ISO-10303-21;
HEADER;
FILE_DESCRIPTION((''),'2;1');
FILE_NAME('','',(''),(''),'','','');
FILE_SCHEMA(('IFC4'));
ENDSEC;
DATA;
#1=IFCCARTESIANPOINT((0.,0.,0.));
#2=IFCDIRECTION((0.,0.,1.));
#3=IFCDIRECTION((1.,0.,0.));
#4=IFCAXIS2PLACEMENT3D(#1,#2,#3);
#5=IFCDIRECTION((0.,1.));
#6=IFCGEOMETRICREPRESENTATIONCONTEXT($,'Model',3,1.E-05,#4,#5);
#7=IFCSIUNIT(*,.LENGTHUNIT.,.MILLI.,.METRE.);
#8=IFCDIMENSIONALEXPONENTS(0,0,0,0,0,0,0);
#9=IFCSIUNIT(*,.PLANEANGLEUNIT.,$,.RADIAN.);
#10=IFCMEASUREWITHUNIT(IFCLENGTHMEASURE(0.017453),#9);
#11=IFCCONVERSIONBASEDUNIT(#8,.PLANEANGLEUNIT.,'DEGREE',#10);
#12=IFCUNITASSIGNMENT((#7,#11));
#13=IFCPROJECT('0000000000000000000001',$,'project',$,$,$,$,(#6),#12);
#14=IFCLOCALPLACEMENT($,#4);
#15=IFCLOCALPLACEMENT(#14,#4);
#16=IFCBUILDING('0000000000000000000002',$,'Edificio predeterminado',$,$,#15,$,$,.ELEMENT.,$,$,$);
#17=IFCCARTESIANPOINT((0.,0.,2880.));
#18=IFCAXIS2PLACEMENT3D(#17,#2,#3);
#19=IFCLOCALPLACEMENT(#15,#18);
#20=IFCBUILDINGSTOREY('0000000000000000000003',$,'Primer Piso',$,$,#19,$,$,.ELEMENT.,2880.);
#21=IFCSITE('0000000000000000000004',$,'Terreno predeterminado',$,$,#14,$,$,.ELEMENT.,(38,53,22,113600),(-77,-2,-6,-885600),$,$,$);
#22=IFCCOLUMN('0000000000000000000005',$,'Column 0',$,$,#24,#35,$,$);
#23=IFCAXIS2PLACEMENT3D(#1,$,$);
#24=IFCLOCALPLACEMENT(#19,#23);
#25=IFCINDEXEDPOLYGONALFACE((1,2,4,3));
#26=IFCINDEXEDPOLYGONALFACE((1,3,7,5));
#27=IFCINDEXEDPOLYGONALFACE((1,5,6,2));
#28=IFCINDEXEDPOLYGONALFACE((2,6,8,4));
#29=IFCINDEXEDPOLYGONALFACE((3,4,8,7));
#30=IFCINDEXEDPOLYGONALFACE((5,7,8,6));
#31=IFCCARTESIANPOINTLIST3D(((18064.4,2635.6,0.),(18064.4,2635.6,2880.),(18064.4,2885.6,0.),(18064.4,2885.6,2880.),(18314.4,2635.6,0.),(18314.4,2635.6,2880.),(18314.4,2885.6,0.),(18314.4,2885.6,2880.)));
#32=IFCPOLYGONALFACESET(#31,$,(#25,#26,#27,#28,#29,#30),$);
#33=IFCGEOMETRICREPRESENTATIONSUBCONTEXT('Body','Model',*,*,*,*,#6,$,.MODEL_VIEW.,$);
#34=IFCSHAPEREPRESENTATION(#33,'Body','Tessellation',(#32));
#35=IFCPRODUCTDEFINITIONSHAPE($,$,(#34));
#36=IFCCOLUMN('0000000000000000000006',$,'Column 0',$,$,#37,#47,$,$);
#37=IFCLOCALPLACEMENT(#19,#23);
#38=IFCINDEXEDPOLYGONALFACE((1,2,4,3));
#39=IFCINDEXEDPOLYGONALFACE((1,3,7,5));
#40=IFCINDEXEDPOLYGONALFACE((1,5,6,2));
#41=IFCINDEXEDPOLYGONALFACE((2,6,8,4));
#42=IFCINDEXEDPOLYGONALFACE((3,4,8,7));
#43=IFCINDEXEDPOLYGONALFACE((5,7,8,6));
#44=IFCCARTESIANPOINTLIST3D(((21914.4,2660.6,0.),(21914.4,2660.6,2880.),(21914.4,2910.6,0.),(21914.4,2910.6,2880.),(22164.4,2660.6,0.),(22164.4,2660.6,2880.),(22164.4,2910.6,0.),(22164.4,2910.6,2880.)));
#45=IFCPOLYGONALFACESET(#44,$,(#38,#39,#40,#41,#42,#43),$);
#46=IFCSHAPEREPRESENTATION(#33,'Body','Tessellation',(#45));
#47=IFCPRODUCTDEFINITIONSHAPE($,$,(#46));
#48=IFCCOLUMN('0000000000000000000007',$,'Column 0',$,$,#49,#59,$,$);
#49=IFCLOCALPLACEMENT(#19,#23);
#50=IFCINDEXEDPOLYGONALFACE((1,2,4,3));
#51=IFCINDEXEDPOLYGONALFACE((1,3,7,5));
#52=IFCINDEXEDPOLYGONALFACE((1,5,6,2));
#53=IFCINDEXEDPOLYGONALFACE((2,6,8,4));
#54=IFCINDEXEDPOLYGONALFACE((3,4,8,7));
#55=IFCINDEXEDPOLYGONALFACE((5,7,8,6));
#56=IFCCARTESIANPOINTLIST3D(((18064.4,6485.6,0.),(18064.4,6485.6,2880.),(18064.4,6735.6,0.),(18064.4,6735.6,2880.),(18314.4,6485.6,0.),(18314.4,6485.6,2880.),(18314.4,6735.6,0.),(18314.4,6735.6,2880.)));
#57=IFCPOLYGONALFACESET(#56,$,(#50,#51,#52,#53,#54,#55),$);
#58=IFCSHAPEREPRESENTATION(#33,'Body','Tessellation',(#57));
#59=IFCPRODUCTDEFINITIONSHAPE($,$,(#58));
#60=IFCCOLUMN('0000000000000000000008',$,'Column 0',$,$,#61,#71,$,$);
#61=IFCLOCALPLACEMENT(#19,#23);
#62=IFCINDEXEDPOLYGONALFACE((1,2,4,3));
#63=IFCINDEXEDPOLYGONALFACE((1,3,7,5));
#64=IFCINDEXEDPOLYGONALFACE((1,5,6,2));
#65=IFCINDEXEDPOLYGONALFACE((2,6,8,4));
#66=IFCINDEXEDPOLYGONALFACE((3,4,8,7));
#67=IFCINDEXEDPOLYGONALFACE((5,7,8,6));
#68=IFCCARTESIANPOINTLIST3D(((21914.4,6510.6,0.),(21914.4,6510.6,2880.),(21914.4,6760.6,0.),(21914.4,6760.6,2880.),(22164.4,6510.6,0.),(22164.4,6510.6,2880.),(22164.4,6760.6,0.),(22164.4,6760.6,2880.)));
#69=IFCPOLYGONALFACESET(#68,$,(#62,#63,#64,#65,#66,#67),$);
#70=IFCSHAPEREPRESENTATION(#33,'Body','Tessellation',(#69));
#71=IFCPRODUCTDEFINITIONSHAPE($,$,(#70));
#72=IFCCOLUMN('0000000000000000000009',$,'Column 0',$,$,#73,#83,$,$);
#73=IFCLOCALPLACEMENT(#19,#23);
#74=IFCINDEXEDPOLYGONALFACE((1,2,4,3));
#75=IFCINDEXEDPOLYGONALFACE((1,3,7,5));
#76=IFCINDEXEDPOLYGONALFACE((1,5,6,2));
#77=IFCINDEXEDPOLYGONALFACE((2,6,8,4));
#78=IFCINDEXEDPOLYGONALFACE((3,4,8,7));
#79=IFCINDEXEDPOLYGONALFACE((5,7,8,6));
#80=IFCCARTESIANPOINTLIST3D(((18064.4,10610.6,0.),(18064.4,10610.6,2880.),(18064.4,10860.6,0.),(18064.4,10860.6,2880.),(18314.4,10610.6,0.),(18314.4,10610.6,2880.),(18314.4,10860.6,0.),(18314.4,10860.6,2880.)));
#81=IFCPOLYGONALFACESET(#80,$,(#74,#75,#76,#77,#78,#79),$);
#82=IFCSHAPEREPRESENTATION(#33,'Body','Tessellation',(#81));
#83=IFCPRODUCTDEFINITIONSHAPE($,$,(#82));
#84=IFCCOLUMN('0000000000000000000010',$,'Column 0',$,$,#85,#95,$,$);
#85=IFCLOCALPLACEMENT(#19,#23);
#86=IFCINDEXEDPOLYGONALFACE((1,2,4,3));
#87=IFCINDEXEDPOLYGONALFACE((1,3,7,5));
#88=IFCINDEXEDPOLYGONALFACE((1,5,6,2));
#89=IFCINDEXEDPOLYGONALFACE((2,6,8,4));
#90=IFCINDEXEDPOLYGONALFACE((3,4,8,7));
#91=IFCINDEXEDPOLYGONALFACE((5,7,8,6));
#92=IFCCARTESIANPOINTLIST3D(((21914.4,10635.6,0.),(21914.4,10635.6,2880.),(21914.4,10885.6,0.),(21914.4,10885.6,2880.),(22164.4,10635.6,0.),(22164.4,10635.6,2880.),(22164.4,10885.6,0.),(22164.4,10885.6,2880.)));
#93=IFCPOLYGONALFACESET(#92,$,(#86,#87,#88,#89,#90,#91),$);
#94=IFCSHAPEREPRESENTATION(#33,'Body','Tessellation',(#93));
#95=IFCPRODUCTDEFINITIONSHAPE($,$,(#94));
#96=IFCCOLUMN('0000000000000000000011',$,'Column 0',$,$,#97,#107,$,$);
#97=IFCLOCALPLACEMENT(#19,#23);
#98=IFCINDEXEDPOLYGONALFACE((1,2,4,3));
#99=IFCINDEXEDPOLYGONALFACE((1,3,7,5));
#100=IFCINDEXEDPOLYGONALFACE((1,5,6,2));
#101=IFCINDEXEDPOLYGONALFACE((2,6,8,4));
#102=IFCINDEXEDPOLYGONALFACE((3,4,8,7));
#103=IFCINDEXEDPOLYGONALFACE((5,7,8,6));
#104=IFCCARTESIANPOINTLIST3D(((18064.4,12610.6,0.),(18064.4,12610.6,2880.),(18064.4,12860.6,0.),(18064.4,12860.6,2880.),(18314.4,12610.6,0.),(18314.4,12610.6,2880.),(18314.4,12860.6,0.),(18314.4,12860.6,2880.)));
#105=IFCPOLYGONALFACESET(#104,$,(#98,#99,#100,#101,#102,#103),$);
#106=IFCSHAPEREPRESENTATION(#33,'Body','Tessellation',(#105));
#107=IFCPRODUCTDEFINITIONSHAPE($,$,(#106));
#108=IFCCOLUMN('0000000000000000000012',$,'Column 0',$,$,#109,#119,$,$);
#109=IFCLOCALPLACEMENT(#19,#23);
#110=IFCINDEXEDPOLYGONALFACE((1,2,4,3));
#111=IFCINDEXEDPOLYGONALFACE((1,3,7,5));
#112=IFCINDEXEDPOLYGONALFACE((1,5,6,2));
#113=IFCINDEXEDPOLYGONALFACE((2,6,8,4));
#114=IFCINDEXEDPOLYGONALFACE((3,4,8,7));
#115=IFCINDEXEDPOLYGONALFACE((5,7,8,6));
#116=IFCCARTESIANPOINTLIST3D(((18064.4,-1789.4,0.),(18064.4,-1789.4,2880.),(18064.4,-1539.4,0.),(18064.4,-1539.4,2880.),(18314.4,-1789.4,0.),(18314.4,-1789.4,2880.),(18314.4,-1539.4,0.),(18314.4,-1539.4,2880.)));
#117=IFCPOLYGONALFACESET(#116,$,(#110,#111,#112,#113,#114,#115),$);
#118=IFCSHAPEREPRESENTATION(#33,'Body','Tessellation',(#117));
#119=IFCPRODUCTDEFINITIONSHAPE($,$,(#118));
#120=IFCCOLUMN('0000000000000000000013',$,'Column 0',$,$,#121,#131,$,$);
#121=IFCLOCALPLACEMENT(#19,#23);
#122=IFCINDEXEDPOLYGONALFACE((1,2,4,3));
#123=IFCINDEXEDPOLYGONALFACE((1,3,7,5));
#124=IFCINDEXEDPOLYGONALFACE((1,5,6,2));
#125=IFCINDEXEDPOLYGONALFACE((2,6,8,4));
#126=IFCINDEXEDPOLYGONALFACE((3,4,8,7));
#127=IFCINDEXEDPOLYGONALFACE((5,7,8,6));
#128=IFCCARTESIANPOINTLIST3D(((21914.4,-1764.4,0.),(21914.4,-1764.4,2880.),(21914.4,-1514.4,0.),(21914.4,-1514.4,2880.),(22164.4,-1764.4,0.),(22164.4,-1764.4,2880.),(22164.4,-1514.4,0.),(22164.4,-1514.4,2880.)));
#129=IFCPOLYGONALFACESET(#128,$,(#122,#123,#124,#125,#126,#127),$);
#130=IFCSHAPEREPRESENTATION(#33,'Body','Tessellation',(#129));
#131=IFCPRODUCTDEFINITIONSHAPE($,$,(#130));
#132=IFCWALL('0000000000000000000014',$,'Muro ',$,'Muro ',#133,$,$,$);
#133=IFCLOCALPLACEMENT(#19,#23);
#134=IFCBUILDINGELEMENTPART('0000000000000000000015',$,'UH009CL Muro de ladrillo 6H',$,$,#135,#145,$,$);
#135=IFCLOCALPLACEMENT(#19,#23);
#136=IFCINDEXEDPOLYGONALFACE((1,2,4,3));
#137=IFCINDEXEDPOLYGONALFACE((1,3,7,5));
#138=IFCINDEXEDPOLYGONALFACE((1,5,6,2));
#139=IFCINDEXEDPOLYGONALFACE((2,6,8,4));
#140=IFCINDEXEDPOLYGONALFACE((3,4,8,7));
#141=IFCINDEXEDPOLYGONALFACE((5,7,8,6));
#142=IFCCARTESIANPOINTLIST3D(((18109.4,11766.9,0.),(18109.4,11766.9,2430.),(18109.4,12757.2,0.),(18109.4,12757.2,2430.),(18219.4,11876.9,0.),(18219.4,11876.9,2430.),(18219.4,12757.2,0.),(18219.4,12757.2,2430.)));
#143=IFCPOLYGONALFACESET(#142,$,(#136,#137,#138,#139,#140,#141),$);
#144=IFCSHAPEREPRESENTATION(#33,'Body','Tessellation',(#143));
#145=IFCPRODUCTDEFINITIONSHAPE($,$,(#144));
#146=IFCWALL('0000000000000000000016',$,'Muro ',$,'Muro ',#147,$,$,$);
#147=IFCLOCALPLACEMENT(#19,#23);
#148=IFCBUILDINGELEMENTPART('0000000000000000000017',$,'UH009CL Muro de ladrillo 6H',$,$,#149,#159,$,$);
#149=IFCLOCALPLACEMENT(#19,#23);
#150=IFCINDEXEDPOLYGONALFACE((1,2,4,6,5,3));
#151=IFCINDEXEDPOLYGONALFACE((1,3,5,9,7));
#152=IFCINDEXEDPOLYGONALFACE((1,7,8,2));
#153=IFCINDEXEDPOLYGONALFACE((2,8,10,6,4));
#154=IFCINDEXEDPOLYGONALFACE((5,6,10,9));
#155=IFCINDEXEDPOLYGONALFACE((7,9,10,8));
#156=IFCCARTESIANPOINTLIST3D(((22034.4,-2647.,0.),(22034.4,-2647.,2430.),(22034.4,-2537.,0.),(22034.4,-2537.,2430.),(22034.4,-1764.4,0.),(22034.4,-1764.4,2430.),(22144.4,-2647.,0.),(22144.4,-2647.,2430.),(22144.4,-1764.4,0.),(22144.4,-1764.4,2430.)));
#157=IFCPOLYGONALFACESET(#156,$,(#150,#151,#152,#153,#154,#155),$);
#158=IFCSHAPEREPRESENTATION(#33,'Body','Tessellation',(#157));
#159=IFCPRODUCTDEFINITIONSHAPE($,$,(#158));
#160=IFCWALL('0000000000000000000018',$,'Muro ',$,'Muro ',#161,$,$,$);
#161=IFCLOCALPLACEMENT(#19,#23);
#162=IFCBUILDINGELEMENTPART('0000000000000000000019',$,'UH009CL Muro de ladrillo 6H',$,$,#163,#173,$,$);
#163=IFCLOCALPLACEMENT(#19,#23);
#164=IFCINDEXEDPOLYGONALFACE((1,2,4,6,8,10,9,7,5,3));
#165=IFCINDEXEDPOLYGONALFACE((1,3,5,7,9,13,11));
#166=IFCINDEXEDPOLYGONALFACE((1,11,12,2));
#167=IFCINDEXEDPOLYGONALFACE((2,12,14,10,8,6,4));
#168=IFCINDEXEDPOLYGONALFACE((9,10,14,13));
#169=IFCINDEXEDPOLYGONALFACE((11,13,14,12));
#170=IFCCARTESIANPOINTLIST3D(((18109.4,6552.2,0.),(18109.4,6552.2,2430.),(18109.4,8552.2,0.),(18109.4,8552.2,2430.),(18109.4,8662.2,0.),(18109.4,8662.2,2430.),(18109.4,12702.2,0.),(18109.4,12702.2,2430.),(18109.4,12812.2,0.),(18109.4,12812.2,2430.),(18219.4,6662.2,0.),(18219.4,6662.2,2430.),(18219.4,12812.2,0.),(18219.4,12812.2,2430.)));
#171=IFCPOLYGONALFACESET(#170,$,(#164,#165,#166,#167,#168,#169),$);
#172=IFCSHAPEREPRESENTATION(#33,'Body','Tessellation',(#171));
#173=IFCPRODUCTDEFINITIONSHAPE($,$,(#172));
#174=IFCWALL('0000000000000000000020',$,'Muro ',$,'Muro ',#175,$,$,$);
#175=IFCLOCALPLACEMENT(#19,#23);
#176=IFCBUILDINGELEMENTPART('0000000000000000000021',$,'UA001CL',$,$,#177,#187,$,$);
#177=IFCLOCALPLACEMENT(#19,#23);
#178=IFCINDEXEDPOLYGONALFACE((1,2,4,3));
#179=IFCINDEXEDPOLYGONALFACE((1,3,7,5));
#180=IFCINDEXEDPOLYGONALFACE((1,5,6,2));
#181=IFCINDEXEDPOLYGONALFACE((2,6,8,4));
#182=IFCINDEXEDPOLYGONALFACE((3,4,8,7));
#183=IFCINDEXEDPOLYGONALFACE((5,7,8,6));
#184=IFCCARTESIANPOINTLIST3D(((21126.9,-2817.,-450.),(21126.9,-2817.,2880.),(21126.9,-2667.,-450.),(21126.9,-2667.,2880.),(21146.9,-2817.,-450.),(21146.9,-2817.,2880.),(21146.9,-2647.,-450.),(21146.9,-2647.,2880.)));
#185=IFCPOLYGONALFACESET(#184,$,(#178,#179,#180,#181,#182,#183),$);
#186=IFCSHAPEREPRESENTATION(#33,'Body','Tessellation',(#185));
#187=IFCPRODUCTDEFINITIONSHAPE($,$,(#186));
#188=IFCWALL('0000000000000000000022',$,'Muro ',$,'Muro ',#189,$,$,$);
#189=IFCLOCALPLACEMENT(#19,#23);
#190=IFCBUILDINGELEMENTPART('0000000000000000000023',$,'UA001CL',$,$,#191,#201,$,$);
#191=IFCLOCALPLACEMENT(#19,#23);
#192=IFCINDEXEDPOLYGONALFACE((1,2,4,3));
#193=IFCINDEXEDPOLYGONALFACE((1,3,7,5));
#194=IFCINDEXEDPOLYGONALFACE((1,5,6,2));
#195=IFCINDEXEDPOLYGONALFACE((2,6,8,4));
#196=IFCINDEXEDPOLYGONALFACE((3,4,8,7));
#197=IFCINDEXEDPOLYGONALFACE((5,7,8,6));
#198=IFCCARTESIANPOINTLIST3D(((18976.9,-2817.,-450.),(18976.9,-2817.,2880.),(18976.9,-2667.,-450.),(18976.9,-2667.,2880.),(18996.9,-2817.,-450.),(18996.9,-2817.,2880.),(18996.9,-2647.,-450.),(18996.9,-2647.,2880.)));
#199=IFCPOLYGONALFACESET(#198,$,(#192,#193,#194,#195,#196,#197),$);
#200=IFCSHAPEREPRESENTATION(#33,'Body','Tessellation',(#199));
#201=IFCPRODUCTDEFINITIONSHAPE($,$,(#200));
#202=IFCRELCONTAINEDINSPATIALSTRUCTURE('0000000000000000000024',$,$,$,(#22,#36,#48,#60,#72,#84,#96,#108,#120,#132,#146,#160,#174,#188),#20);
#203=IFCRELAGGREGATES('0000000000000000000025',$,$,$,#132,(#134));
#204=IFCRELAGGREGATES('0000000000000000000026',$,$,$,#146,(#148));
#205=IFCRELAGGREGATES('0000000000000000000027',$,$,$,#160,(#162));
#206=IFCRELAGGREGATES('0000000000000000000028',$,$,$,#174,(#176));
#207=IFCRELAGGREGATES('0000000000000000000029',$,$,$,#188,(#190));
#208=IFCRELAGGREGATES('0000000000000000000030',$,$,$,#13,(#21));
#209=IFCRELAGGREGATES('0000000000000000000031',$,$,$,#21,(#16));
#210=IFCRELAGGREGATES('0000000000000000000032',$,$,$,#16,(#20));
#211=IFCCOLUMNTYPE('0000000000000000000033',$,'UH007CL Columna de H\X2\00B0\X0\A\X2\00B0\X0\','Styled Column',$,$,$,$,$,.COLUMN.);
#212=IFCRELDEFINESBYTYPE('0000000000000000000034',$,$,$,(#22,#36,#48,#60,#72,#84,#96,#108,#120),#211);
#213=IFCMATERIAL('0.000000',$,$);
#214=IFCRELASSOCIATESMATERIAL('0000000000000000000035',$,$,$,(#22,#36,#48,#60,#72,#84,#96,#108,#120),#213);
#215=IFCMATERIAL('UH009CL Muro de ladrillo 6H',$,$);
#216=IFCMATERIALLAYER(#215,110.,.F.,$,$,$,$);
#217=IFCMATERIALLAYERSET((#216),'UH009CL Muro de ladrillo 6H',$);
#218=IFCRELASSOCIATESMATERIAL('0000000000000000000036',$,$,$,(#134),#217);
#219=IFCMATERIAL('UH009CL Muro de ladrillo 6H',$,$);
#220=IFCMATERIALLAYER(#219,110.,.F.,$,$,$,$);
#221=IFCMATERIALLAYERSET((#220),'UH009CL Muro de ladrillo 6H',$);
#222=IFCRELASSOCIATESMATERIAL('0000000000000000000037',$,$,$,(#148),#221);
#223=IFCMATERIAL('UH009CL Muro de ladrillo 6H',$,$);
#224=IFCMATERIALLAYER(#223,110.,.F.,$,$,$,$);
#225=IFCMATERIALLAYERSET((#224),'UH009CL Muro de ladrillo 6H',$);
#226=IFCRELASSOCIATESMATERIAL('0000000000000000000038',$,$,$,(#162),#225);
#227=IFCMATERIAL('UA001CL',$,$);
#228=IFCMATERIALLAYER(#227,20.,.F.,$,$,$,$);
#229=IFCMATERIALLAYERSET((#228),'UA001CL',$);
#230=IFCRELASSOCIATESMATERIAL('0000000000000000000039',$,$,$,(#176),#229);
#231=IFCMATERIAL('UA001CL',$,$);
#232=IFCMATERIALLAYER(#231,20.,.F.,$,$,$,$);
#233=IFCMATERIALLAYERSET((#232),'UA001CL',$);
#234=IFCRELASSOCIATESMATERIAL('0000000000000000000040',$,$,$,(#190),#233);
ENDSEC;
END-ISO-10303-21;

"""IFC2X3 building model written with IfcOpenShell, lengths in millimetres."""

from ifc_helpers import new_model, entity, si_unit, converted_unit, direction, frame, origin_with_axes, place, context, subcontext, project, spatial, polyline, outline, extrude, clip, bounded_halfspace, material, layer, layer_set, layer_usage, type_object, element, aggregate, save


model = new_model("IFC2X3")

# Units and contexts
model_context = context("Model", 3, precision=1e-05, world=origin_with_axes(), true_north=direction((0.0, 1.0)))
body_context = subcontext(model_context, "Body", "Model", "MODEL_VIEW")
ifc_project = project(units=[si_unit("LENGTHUNIT", "METRE", prefix="MILLI"), converted_unit("PLANEANGLEUNIT", "DEGREE", entity("IfcLengthMeasure", 0.017453), si_unit("PLANEANGLEUNIT", "RADIAN"), dimensions=[0, 0, 0, 0, 0, 0, 0])], contexts=[model_context])

# Site, building, storey
site_placement = place(None, origin_with_axes())
site = spatial("IfcSite", under=ifc_project, at=site_placement, Name="Terreno predeterminado", CompositionType="ELEMENT", RefLatitude=(38, 53, 22, 113600), RefLongitude=(-77, -2, -6, -885600))
building_placement = place(site_placement, origin_with_axes())
building = spatial("IfcBuilding", under=site, at=building_placement, Name="Edificio predeterminado", CompositionType="ELEMENT")
storey_placement = place(building_placement, frame((0.0, 0.0, 2880.0), z_axis=(0.0, 0.0, 1.0), x_axis=(1.0, 0.0, 0.0)))
storey = spatial("IfcBuildingStorey", under=building, at=storey_placement, Name="Primer Piso", CompositionType="ELEMENT", Elevation=2880.0)

# Columns
ifc_material_1 = material(Name="0.000000")
column_type = type_object("IfcColumnType", Name="UH007CL Columna de H°A°", Description="Styled Column", PredefinedType="COLUMN")
for number, where, z_axis, x_axis, name in (
    (1, (18189.4, 2760.6, 0.0), (0.0, 0.0, 1.0), (1.0, 0.0, 0.0), "Column 0"),
    (2, (22039.4, 2785.6, 0.0), (0.0, 0.0, 1.0), (1.0, 0.0, 0.0), "Column 0"),
    (3, (18189.4, 6610.6, 0.0), (0.0, 0.0, 1.0), (1.0, 0.0, 0.0), "Column 0"),
    (4, (22039.4, 6635.6, 0.0), (0.0, 0.0, 1.0), (1.0, 0.0, 0.0), "Column 0"),
    (5, (18189.4, 10735.6, 0.0), (0.0, 0.0, 1.0), (1.0, 0.0, 0.0), "Column 0"),
    (6, (22039.4, 10760.6, 0.0), (0.0, 0.0, 1.0), (1.0, 0.0, 0.0), "Column 0"),
    (7, (18189.4, 12735.6, 0.0), (0.0, 0.0, 1.0), (1.0, 0.0, 0.0), "Column 0"),
    (8, (18189.4, -1664.4, 0.0), (0.0, 0.0, 1.0), (1.0, 0.0, 0.0), "Column 0"),
    (9, (22039.4, -1639.4, 0.0), (0.0, 0.0, 1.0), (1.0, 0.0, 0.0), "Column 0"),
):
    element("IfcColumn", number, at=place(storey_placement, frame(where, z_axis=z_axis, x_axis=x_axis)), inside=storey, type_object=column_type, material=ifc_material_1, Name=name, context=body_context, shape_type="SweptSolid", body=[
        extrude(outline(polyline([(-125.0, -125.0), (125.0, -125.0), (125.0, 125.0), (-125.0, 125.0), (-125.0, -125.0)])), origin_with_axes(), (0.0, 0.0, 1.0), 2880.0),
    ])

# Walls, building element parts
wall_1_placement = place(storey_placement, frame((18164.4, 11821.9, 0.0), z_axis=(0.0, 0.0, 1.0), x_axis=(0.0, 1.0, 0.0)))
wall_1 = element("IfcWall", 10, at=wall_1_placement, inside=storey, Name="Muro ", ObjectType="Muro ")
ifc_material_2 = material(Name="UH009CL Muro de ladrillo 6H")
ifc_layer_1 = layer(ifc_material_2, 110.0, ventilated=False)
ifc_layer_set_1 = layer_set([ifc_layer_1], Name="UH009CL Muro de ladrillo 6H")
ifc_layer_usage_1 = layer_usage(ifc_layer_set_1, "AXIS2", "NEGATIVE", -55.0)
building_element_part_1_placement = place(wall_1_placement, origin_with_axes())
building_element_part_1 = element("IfcBuildingElementPart", 11, at=building_element_part_1_placement, material=ifc_layer_usage_1, Name="UH009CL Muro de ladrillo 6H", context=body_context, shape_type="SweptSolid", body=[
    extrude(outline(polyline([(935.2, 55.0), (935.2, -55.0), (55.0, -55.0), (-55.0, 55.0), (935.2, 55.0)])), origin_with_axes(), (0.0, 0.0, 1.0), 2430.0),
])
aggregate(wall_1, [building_element_part_1])
wall_2_placement = place(storey_placement, frame((22089.4, -1764.4, 0.0), z_axis=(0.0, 0.0, 1.0), x_axis=(0.0, -1.0, 0.0)))
wall_2 = element("IfcWall", 12, at=wall_2_placement, inside=storey, Name="Muro ", ObjectType="Muro ")
ifc_material_3 = material(Name="UH009CL Muro de ladrillo 6H")
ifc_layer_2 = layer(ifc_material_3, 110.0, ventilated=False)
ifc_layer_set_2 = layer_set([ifc_layer_2], Name="UH009CL Muro de ladrillo 6H")
ifc_layer_usage_2 = layer_usage(ifc_layer_set_2, "AXIS2", "NEGATIVE", -55.0)
building_element_part_2_placement = place(wall_2_placement, origin_with_axes())
building_element_part_2 = element("IfcBuildingElementPart", 13, at=building_element_part_2_placement, material=ifc_layer_usage_2, Name="UH009CL Muro de ladrillo 6H", context=body_context, shape_type="SweptSolid", body=[
    extrude(outline(polyline([(882.6, 55.0), (882.6, -55.0), (772.6, -55.0), (0.0, -55.0), (0.0, 55.0), (882.6, 55.0)])), origin_with_axes(), (0.0, 0.0, 1.0), 2430.0),
])
aggregate(wall_2, [building_element_part_2])
wall_3_placement = place(storey_placement, frame((18164.4, 12757.2, 0.0), z_axis=(0.0, 0.0, 1.0), x_axis=(0.0, -1.0, 0.0)))
wall_3 = element("IfcWall", 14, at=wall_3_placement, inside=storey, Name="Muro ", ObjectType="Muro ")
ifc_material_4 = material(Name="UH009CL Muro de ladrillo 6H")
ifc_layer_3 = layer(ifc_material_4, 110.0, ventilated=False)
ifc_layer_set_3 = layer_set([ifc_layer_3], Name="UH009CL Muro de ladrillo 6H")
ifc_layer_usage_3 = layer_usage(ifc_layer_set_3, "AXIS2", "NEGATIVE", -55.0)
building_element_part_3_placement = place(wall_3_placement, origin_with_axes())
building_element_part_3 = element("IfcBuildingElementPart", 15, at=building_element_part_3_placement, material=ifc_layer_usage_3, Name="UH009CL Muro de ladrillo 6H", context=body_context, shape_type="SweptSolid", body=[
    extrude(outline(polyline([(6095.0, 55.0), (6205.0, -55.0), (4205.0, -55.0), (4095.0, -55.0), (55.0, -55.0), (-55.0, -55.0), (-55.0, 55.0), (6095.0, 55.0)])), origin_with_axes(), (0.0, 0.0, 1.0), 2430.0),
])
aggregate(wall_3, [building_element_part_3])
wall_4_placement = place(storey_placement, frame((21201.9, -2817.0, 0.0), z_axis=(0.0, 0.0, 1.0), x_axis=(0.0, 1.0, 0.0)))
wall_4 = element("IfcWall", 16, at=wall_4_placement, inside=storey, Name="Muro ", ObjectType="Muro ")
ifc_material_5 = material(Name="UA001CL")
ifc_layer_4 = layer(ifc_material_5, 20.0, ventilated=False)
ifc_layer_set_4 = layer_set([ifc_layer_4], Name="UA001CL")
ifc_layer_usage_4 = layer_usage(ifc_layer_set_4, "AXIS2", "NEGATIVE", -75.0)
building_element_part_4_placement = place(wall_4_placement, origin_with_axes())
building_element_part_4 = element("IfcBuildingElementPart", 17, at=building_element_part_4_placement, material=ifc_layer_usage_4, Name="UA001CL", context=body_context, shape_type="Clipping", body=[
    clip(clip(extrude(outline(polyline([(150.0, 75.0), (170.0, 55.0), (0.0, 55.0), (0.0, 75.0), (150.0, 75.0)])), frame((0.0, 0.0, -450.0), z_axis=(0.0, 0.0, 1.0), x_axis=(1.0, 0.0, 0.0)), (0.0, 0.0, 1.0), 3330.0), bounded_halfspace(frame((0.0, 0.0, -450.0), z_axis=(0.0, 0.0, 1.0), x_axis=(1.0, 0.0, 0.0)), True, origin_with_axes(), polyline([(-150.0, -150.0), (375.0, -150.0), (375.0, 150.0), (-150.0, 150.0), (-150.0, -150.0)]))), bounded_halfspace(frame((0.0, 0.0, 2880.0), z_axis=(0.0, 0.0, 1.0), x_axis=(1.0, 0.0, 0.0)), False, origin_with_axes(), polyline([(-150.0, -150.0), (375.0, -150.0), (375.0, 150.0), (-150.0, 150.0), (-150.0, -150.0)]))),
])
aggregate(wall_4, [building_element_part_4])
wall_5_placement = place(storey_placement, frame((19051.9, -2817.0, 0.0), z_axis=(0.0, 0.0, 1.0), x_axis=(0.0, 1.0, 0.0)))
wall_5 = element("IfcWall", 18, at=wall_5_placement, inside=storey, Name="Muro ", ObjectType="Muro ")
ifc_material_6 = material(Name="UA001CL")
ifc_layer_5 = layer(ifc_material_6, 20.0, ventilated=False)
ifc_layer_set_5 = layer_set([ifc_layer_5], Name="UA001CL")
ifc_layer_usage_5 = layer_usage(ifc_layer_set_5, "AXIS2", "NEGATIVE", -75.0)
building_element_part_5_placement = place(wall_5_placement, origin_with_axes())
building_element_part_5 = element("IfcBuildingElementPart", 19, at=building_element_part_5_placement, material=ifc_layer_usage_5, Name="UA001CL", context=body_context, shape_type="Clipping", body=[
    clip(clip(extrude(outline(polyline([(150.0, 75.0), (170.0, 55.0), (0.0, 55.0), (0.0, 75.0), (150.0, 75.0)])), frame((0.0, 0.0, -450.0), z_axis=(0.0, 0.0, 1.0), x_axis=(1.0, 0.0, 0.0)), (0.0, 0.0, 1.0), 3330.0), bounded_halfspace(frame((0.0, 0.0, -450.0), z_axis=(0.0, 0.0, 1.0), x_axis=(1.0, 0.0, 0.0)), True, origin_with_axes(), polyline([(-150.0, -150.0), (375.0, -150.0), (375.0, 150.0), (-150.0, 150.0), (-150.0, -150.0)]))), bounded_halfspace(frame((0.0, 0.0, 2880.0), z_axis=(0.0, 0.0, 1.0), x_axis=(1.0, 0.0, 0.0)), False, origin_with_axes(), polyline([(-150.0, -150.0), (375.0, -150.0), (375.0, 150.0), (-150.0, 150.0), (-150.0, -150.0)]))),
])
aggregate(wall_5, [building_element_part_5])

save(model, "model.ifc")
